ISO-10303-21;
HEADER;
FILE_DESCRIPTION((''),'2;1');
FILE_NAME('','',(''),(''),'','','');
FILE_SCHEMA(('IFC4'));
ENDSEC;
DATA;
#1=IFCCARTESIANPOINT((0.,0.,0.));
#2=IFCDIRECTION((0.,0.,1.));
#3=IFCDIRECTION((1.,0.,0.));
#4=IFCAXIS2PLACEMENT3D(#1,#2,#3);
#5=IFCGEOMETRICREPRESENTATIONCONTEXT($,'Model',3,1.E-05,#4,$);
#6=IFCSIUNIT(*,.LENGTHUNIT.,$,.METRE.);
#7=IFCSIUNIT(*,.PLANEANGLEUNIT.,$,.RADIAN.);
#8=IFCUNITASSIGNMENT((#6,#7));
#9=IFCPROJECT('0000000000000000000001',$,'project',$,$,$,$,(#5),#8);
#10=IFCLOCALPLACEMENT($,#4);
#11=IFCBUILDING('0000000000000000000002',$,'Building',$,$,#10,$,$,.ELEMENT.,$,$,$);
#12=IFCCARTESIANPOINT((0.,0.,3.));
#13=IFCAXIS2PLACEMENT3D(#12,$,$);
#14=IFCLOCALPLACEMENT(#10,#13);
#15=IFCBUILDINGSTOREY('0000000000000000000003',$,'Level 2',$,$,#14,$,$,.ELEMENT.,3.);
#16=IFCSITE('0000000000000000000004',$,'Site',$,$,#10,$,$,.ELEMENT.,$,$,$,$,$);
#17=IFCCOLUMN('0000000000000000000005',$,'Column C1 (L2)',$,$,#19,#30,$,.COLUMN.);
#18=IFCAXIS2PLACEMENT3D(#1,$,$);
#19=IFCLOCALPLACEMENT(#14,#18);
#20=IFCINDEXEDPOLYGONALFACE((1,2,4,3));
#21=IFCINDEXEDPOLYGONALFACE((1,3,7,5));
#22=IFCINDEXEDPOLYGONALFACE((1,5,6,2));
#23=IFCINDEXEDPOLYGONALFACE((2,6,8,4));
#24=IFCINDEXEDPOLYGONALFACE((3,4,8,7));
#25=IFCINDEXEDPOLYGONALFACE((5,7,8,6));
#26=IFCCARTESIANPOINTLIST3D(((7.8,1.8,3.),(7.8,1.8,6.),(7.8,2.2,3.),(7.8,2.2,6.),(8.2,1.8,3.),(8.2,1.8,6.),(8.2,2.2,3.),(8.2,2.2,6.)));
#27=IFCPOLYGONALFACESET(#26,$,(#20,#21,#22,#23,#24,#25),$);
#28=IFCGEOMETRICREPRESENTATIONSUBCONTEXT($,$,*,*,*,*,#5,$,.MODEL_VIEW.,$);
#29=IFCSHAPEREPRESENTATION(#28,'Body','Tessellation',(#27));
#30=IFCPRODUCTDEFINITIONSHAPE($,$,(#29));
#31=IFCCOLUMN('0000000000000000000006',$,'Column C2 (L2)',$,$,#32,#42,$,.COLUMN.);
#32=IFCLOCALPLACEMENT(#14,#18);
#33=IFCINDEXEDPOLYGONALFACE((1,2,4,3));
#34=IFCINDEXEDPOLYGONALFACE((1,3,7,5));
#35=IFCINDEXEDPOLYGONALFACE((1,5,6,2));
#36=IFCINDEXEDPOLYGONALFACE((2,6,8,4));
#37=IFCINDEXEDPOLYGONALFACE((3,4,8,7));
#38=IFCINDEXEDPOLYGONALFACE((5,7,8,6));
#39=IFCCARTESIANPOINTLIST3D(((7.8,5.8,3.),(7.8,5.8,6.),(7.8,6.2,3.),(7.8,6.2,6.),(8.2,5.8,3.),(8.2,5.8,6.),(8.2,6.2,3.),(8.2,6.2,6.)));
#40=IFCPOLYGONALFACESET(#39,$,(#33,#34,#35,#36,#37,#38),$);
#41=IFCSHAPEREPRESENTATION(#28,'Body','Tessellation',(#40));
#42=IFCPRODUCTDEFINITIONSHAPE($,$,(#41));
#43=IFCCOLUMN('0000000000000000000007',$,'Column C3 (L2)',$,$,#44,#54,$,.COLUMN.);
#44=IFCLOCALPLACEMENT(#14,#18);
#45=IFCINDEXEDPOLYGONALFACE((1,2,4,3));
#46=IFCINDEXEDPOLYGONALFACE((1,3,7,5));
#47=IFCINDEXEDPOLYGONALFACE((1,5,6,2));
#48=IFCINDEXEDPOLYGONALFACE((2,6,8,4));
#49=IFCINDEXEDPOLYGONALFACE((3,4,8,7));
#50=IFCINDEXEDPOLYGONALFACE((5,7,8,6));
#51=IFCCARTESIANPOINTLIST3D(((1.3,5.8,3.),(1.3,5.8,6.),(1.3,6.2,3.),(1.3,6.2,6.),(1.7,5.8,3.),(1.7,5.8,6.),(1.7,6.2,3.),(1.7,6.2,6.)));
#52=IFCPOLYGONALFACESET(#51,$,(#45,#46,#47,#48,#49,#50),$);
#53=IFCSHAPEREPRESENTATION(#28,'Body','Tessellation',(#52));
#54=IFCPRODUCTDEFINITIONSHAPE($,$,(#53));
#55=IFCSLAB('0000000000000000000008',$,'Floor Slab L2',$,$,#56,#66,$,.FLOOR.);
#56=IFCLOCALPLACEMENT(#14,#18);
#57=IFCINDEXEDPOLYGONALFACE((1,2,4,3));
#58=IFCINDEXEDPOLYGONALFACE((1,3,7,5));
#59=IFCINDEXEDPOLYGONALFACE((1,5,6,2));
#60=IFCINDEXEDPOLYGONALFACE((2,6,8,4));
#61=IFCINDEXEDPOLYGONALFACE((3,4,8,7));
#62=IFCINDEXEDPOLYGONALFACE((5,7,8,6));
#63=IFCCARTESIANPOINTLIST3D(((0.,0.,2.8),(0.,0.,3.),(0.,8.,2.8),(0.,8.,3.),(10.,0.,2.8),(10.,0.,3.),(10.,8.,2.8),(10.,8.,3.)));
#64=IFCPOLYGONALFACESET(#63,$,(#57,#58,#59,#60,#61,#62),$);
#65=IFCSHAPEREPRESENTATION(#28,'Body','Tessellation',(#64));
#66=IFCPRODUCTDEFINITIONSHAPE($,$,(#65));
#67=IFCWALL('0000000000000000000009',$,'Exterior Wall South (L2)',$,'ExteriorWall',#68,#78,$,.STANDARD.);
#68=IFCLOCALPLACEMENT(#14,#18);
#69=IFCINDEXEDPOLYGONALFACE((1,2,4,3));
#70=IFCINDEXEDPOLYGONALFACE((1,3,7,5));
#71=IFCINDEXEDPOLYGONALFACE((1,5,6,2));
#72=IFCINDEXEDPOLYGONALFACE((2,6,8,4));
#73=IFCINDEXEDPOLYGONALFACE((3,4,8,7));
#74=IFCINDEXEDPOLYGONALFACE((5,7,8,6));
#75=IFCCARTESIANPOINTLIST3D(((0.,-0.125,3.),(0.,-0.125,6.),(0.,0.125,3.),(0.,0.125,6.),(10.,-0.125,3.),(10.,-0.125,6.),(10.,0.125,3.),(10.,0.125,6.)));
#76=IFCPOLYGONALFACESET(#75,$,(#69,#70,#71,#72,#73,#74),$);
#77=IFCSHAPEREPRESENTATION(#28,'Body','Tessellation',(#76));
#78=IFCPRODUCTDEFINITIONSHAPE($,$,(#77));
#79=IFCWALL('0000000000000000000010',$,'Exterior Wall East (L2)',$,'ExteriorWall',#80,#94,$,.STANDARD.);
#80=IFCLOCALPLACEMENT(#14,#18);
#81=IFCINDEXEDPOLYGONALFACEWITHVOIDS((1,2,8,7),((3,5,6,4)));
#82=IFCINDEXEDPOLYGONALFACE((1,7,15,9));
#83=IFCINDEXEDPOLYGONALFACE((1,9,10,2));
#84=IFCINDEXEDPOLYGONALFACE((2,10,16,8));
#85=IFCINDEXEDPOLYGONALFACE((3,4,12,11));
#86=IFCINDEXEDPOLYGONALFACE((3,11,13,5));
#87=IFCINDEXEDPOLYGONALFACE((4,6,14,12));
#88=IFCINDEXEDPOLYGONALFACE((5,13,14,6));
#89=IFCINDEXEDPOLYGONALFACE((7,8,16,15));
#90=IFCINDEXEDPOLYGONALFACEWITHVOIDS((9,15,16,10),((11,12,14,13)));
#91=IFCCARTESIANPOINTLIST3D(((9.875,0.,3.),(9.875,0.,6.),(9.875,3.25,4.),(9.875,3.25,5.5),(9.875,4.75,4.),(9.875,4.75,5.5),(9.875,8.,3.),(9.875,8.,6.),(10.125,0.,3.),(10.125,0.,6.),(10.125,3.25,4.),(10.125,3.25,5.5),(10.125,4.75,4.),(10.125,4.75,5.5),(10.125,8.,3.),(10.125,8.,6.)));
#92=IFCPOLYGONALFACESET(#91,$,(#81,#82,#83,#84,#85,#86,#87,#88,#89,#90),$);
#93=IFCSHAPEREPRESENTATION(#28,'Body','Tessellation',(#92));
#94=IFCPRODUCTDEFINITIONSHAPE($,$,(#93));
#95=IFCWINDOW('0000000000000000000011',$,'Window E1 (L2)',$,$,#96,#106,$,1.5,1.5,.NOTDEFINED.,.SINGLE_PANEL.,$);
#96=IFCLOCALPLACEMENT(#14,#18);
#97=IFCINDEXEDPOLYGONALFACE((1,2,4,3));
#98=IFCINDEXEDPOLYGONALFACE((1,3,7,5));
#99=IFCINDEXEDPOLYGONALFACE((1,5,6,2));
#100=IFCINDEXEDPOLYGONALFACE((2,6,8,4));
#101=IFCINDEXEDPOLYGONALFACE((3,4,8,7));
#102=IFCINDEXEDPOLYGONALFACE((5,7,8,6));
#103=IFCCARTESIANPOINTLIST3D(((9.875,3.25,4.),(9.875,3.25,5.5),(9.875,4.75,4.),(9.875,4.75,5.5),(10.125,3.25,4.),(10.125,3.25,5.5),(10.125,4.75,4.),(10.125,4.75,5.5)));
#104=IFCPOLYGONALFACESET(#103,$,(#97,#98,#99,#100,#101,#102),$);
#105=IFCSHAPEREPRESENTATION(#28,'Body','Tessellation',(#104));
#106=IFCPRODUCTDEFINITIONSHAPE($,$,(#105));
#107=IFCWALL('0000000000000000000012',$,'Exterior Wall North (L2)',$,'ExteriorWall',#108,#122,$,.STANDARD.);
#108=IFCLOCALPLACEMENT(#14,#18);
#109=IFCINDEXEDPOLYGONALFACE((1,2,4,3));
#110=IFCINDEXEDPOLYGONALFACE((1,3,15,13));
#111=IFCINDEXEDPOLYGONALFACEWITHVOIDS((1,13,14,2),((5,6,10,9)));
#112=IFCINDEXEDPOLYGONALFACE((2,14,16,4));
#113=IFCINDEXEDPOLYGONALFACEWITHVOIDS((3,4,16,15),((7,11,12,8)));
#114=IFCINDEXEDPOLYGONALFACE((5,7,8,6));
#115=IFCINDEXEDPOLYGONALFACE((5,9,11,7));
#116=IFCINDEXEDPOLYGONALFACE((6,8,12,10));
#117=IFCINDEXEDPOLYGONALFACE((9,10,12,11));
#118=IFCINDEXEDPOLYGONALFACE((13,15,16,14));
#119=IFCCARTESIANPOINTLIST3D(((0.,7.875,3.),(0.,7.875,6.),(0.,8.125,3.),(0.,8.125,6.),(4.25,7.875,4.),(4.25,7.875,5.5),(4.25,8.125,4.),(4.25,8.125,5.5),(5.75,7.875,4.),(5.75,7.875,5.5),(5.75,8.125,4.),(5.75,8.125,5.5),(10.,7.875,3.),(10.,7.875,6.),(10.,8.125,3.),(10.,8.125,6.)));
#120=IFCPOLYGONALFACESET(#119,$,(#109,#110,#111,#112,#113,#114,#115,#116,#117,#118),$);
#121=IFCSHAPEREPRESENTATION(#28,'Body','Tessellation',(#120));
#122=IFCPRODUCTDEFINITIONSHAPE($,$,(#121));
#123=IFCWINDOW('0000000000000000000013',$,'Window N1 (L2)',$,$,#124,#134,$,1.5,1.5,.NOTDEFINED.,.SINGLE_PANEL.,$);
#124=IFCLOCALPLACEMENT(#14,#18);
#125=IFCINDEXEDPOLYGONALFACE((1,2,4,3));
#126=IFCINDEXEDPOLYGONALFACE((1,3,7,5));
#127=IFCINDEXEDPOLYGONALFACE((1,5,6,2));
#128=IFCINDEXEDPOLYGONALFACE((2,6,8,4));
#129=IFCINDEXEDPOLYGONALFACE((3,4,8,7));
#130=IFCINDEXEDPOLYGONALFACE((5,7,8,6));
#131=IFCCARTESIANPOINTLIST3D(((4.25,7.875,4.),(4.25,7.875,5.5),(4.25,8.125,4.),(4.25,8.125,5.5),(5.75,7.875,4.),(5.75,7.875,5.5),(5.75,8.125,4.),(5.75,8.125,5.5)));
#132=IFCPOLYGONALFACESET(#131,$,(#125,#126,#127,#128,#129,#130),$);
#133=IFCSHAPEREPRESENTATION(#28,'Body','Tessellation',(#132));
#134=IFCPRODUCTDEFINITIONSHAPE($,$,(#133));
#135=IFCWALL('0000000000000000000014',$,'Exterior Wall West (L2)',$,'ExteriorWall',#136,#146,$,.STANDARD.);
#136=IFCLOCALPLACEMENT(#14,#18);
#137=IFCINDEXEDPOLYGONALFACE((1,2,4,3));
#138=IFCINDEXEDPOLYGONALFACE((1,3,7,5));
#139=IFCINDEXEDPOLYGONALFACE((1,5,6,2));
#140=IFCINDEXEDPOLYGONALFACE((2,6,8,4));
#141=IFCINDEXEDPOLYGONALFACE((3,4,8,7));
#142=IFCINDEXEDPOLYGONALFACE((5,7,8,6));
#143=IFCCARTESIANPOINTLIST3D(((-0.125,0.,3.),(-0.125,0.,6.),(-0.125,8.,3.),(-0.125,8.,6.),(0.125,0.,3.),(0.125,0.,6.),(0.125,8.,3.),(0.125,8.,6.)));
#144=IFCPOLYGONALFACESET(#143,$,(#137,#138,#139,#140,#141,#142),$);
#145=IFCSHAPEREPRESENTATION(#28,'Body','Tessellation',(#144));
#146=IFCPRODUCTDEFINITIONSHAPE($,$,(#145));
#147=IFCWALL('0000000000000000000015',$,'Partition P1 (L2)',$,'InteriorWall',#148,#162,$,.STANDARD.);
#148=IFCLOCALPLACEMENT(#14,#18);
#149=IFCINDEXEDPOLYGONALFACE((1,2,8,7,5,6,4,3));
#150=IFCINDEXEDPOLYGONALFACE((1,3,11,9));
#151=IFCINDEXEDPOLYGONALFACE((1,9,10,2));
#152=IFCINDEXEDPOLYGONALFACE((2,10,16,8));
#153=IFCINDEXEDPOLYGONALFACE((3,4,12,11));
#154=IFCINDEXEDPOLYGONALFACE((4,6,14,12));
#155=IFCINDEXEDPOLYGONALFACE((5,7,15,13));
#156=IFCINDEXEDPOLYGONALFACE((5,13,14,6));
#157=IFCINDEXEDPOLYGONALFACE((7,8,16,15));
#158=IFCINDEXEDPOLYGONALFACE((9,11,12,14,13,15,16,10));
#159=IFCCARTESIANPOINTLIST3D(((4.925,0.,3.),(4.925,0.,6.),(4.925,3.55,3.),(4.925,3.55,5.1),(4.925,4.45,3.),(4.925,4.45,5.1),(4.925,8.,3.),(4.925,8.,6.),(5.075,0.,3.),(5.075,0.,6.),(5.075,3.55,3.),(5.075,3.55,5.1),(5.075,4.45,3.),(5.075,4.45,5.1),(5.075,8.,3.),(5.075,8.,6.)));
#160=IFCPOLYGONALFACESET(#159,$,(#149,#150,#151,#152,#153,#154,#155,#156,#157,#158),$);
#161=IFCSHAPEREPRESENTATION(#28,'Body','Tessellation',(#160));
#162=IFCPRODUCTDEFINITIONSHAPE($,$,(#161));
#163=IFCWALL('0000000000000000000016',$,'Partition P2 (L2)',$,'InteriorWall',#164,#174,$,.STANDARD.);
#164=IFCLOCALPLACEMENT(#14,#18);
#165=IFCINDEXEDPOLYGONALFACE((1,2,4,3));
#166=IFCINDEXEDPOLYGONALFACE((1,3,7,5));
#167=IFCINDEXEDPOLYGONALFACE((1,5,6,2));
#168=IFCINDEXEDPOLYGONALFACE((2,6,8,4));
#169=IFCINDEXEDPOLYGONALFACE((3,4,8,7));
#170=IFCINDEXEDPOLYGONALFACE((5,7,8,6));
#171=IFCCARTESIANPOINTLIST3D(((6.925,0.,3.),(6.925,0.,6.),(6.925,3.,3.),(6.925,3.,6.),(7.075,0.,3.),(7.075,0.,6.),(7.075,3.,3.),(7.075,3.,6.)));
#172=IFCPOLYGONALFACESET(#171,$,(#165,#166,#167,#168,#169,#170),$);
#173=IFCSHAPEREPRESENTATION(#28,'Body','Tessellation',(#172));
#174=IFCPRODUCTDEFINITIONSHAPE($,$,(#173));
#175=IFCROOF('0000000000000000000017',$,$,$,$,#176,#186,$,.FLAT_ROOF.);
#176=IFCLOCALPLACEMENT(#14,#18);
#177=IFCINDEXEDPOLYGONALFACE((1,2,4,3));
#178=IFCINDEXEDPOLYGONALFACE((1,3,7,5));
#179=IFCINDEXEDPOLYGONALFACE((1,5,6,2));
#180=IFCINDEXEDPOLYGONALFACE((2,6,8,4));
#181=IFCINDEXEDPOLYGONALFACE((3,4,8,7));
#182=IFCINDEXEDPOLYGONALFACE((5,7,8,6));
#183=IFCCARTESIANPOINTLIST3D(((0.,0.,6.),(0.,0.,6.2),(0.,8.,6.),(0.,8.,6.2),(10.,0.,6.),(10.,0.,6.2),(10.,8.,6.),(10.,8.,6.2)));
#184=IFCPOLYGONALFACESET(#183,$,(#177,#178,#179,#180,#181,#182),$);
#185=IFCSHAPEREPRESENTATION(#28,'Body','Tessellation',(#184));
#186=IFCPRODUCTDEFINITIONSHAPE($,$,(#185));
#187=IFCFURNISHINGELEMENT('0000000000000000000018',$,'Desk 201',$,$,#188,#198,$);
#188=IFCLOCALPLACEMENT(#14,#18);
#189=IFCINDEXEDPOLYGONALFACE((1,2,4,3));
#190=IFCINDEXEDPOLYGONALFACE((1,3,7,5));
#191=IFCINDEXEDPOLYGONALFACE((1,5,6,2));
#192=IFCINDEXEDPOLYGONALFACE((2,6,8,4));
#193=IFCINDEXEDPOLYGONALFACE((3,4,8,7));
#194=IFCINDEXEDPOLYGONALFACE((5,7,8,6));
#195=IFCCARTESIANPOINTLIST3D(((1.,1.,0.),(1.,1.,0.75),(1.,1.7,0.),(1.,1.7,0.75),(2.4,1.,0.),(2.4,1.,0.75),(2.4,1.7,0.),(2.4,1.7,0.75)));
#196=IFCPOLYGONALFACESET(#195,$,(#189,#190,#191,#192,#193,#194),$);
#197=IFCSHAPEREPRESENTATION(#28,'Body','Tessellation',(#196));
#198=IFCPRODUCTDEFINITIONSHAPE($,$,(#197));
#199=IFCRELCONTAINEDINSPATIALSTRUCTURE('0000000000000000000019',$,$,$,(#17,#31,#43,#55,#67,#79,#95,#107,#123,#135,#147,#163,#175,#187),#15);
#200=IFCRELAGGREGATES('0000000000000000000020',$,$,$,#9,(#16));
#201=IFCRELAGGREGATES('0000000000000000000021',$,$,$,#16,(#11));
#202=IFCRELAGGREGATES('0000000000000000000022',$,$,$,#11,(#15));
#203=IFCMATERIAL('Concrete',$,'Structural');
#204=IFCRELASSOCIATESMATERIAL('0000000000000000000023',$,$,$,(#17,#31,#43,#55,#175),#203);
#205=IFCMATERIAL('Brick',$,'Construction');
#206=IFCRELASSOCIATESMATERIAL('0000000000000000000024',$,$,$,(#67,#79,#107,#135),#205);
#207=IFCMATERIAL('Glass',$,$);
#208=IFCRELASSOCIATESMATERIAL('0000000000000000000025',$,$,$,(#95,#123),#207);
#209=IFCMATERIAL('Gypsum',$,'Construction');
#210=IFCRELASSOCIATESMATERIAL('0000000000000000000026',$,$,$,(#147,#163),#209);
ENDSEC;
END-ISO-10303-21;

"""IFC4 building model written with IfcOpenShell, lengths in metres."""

from ifc_helpers import new_model, si_unit, frame, frame_2d, origin, origin_with_axes, origin_2d, place, context, subcontext, project, spatial, rectangle, extrude, material, element, fill, save


model = new_model("IFC4")

# Units and contexts
model_context = context("Model", 3, precision=1e-05, world=origin_with_axes())
sub_context = subcontext(model_context, None, None, "MODEL_VIEW")
ifc_project = project(units=[si_unit("LENGTHUNIT", "METRE"), si_unit("PLANEANGLEUNIT", "RADIAN")], contexts=[model_context])

# Site, building, storey
placement = place(None, origin_with_axes())
site = spatial("IfcSite", under=ifc_project, at=placement, Name="Site", CompositionType="ELEMENT")
building = spatial("IfcBuilding", under=site, at=placement, Name="Building", CompositionType="ELEMENT")
storey_placement = place(placement, frame((0.0, 0.0, 3.0)))
storey = spatial("IfcBuildingStorey", under=building, at=storey_placement, Name="Level 2", CompositionType="ELEMENT", Elevation=3.0)

# Columns
ifc_material_1 = material(Name="Concrete", Category="Structural")
for number, where, name in (
    (1, (8.0, 2.0, 3.0), "Column C1 (L2)"),
    (2, (8.0, 6.0, 3.0), "Column C2 (L2)"),
    (3, (1.5, 6.0, 3.0), "Column C3 (L2)"),
):
    element("IfcColumn", number, at=place(storey_placement, frame(where)), inside=storey, material=ifc_material_1, Name=name, PredefinedType="COLUMN", context=sub_context, shape_type="SweptSolid", body=[
        extrude(rectangle(XDim=0.4, YDim=0.4, at=origin_2d()), origin(), (0.0, 0.0, 1.0), 3.0),
    ])

# Slab
slab_placement = place(storey_placement, frame((0.0, 0.0, 2.8)))
element("IfcSlab", 4, at=slab_placement, inside=storey, material=ifc_material_1, Name="Floor Slab L2", PredefinedType="FLOOR", context=sub_context, shape_type="SweptSolid", body=[
    extrude(rectangle(XDim=10.0, YDim=8.0, at=frame_2d((5.0, 4.0))), origin(), (0.0, 0.0, 1.0), 0.2),
])

# Wall
ifc_material_2 = material(Name="Brick", Category="Construction")
wall_1_placement = place(storey_placement, frame((0.0, 0.0, 3.0), x_axis=(1.0, 0.0, 0.0)))
element("IfcWall", 5, at=wall_1_placement, inside=storey, material=ifc_material_2, Name="Exterior Wall South (L2)", ObjectType="ExteriorWall", PredefinedType="STANDARD", context=sub_context, shape_type="SweptSolid", body=[
    extrude(rectangle(XDim=10.0, YDim=0.25, at=frame_2d((5.0, 0.0))), origin(), (0.0, 0.0, 1.0), 3.0),
])

# Walls, openings, windows
wall_2_placement = place(storey_placement, frame((10.0, 0.0, 3.0), x_axis=(0.0, 1.0, 0.0)))
wall_2 = element("IfcWall", 6, at=wall_2_placement, inside=storey, material=ifc_material_2, Name="Exterior Wall East (L2)", ObjectType="ExteriorWall", PredefinedType="STANDARD", context=sub_context, shape_type="SweptSolid", body=[
    extrude(rectangle(XDim=8.0, YDim=0.25, at=frame_2d((4.0, 0.0))), origin(), (0.0, 0.0, 1.0), 3.0),
])
opening_1_placement = place(wall_2_placement, frame((4.0, 0.175, 1.0), z_axis=(0.0, -1.0, 0.0), x_axis=(1.0, 0.0, 0.0)))
opening_1 = element("IfcOpeningElement", 7, at=opening_1_placement, cuts=wall_2, PredefinedType="OPENING", context=sub_context, shape_type="SweptSolid", body=[
    extrude(rectangle(XDim=1.5, YDim=1.5, at=frame_2d((0.0, 0.75))), origin(), (0.0, 0.0, 1.0), 0.35),
])
ifc_material_3 = material(Name="Glass")
window_1_placement = place(wall_2_placement, frame((4.0, 0.125, 1.0), z_axis=(0.0, -1.0, 0.0), x_axis=(1.0, 0.0, 0.0)))
window_1 = element("IfcWindow", 8, at=window_1_placement, inside=storey, material=ifc_material_3, Name="Window E1 (L2)", OverallHeight=1.5, OverallWidth=1.5, PartitioningType="SINGLE_PANEL", PredefinedType="NOTDEFINED", context=sub_context, shape_type="SweptSolid", body=[
    extrude(rectangle(XDim=1.5, YDim=1.5, at=frame_2d((0.0, 0.75))), origin(), (0.0, 0.0, 1.0), 0.25),
])
fill(opening_1, window_1)
wall_3_placement = place(storey_placement, frame((10.0, 8.0, 3.0), x_axis=(-1.0, 0.0, 0.0)))
wall_3 = element("IfcWall", 9, at=wall_3_placement, inside=storey, material=ifc_material_2, Name="Exterior Wall North (L2)", ObjectType="ExteriorWall", PredefinedType="STANDARD", context=sub_context, shape_type="SweptSolid", body=[
    extrude(rectangle(XDim=10.0, YDim=0.25, at=frame_2d((5.0, 0.0))), origin(), (0.0, 0.0, 1.0), 3.0),
])
opening_2_placement = place(wall_3_placement, frame((5.0, 0.175, 1.0), z_axis=(0.0, -1.0, 0.0), x_axis=(1.0, 0.0, 0.0)))
opening_2 = element("IfcOpeningElement", 10, at=opening_2_placement, cuts=wall_3, PredefinedType="OPENING", context=sub_context, shape_type="SweptSolid", body=[
    extrude(rectangle(XDim=1.5, YDim=1.5, at=frame_2d((0.0, 0.75))), origin(), (0.0, 0.0, 1.0), 0.35),
])
window_2_placement = place(wall_3_placement, frame((5.0, 0.125, 1.0), z_axis=(0.0, -1.0, 0.0), x_axis=(1.0, 0.0, 0.0)))
window_2 = element("IfcWindow", 11, at=window_2_placement, inside=storey, material=ifc_material_3, Name="Window N1 (L2)", OverallHeight=1.5, OverallWidth=1.5, PartitioningType="SINGLE_PANEL", PredefinedType="NOTDEFINED", context=sub_context, shape_type="SweptSolid", body=[
    extrude(rectangle(XDim=1.5, YDim=1.5, at=frame_2d((0.0, 0.75))), origin(), (0.0, 0.0, 1.0), 0.25),
])
fill(opening_2, window_2)

# Wall
wall_4_placement = place(storey_placement, frame((0.0, 8.0, 3.0), x_axis=(0.0, -1.0, 0.0)))
element("IfcWall", 12, at=wall_4_placement, inside=storey, material=ifc_material_2, Name="Exterior Wall West (L2)", ObjectType="ExteriorWall", PredefinedType="STANDARD", context=sub_context, shape_type="SweptSolid", body=[
    extrude(rectangle(XDim=8.0, YDim=0.25, at=frame_2d((4.0, 0.0))), origin(), (0.0, 0.0, 1.0), 3.0),
])

# Wall, opening
ifc_material_4 = material(Name="Gypsum", Category="Construction")
wall_5_placement = place(storey_placement, frame((5.0, 0.0, 3.0), x_axis=(0.0, 1.0, 0.0)))
wall_5 = element("IfcWall", 13, at=wall_5_placement, inside=storey, material=ifc_material_4, Name="Partition P1 (L2)", ObjectType="InteriorWall", PredefinedType="STANDARD", context=sub_context, shape_type="SweptSolid", body=[
    extrude(rectangle(XDim=8.0, YDim=0.15, at=frame_2d((4.0, 0.0))), origin(), (0.0, 0.0, 1.0), 3.0),
])
opening_3_placement = place(wall_5_placement, frame((4.0, 0.125, 0.0), z_axis=(0.0, -1.0, 0.0), x_axis=(1.0, 0.0, 0.0)))
element("IfcOpeningElement", 14, at=opening_3_placement, cuts=wall_5, PredefinedType="OPENING", context=sub_context, shape_type="SweptSolid", body=[
    extrude(rectangle(XDim=0.9, YDim=2.1, at=frame_2d((0.0, 1.05))), origin(), (0.0, 0.0, 1.0), 0.25),
])

# Wall
wall_6_placement = place(storey_placement, frame((7.0, 0.0, 3.0), x_axis=(0.0, 1.0, 0.0)))
element("IfcWall", 15, at=wall_6_placement, inside=storey, material=ifc_material_4, Name="Partition P2 (L2)", ObjectType="InteriorWall", PredefinedType="STANDARD", context=sub_context, shape_type="SweptSolid", body=[
    extrude(rectangle(XDim=3.0, YDim=0.15, at=frame_2d((1.5, 0.0))), origin(), (0.0, 0.0, 1.0), 3.0),
])

# Roof
roof_placement = place(storey_placement, frame((0.0, 0.0, 6.0), z_axis=(0.0, 0.0, 1.0), x_axis=(1.0, 0.0, 0.0)))
element("IfcRoof", 16, at=roof_placement, inside=storey, material=ifc_material_1, PredefinedType="FLAT_ROOF", context=sub_context, shape_type="SweptSolid", body=[
    extrude(rectangle(XDim=10.0, YDim=8.0, at=frame_2d((5.0, 4.0))), origin(), (0.0, 0.0, 1.0), 0.2),
])

# Furnishing element
for number, where, name in (
    (17, (1.0, 1.0, 3.0), "Desk 201"),
):
    element("IfcFurnishingElement", number, at=place(placement, frame(where)), inside=storey, Name=name, context=sub_context, shape_type="SweptSolid", body=[
        extrude(rectangle(XDim=1.4, YDim=0.7, at=frame_2d((0.7, 0.35))), origin(), (0.0, 0.0, 1.0), 0.75),
    ])

save(model, "model.ifc")
